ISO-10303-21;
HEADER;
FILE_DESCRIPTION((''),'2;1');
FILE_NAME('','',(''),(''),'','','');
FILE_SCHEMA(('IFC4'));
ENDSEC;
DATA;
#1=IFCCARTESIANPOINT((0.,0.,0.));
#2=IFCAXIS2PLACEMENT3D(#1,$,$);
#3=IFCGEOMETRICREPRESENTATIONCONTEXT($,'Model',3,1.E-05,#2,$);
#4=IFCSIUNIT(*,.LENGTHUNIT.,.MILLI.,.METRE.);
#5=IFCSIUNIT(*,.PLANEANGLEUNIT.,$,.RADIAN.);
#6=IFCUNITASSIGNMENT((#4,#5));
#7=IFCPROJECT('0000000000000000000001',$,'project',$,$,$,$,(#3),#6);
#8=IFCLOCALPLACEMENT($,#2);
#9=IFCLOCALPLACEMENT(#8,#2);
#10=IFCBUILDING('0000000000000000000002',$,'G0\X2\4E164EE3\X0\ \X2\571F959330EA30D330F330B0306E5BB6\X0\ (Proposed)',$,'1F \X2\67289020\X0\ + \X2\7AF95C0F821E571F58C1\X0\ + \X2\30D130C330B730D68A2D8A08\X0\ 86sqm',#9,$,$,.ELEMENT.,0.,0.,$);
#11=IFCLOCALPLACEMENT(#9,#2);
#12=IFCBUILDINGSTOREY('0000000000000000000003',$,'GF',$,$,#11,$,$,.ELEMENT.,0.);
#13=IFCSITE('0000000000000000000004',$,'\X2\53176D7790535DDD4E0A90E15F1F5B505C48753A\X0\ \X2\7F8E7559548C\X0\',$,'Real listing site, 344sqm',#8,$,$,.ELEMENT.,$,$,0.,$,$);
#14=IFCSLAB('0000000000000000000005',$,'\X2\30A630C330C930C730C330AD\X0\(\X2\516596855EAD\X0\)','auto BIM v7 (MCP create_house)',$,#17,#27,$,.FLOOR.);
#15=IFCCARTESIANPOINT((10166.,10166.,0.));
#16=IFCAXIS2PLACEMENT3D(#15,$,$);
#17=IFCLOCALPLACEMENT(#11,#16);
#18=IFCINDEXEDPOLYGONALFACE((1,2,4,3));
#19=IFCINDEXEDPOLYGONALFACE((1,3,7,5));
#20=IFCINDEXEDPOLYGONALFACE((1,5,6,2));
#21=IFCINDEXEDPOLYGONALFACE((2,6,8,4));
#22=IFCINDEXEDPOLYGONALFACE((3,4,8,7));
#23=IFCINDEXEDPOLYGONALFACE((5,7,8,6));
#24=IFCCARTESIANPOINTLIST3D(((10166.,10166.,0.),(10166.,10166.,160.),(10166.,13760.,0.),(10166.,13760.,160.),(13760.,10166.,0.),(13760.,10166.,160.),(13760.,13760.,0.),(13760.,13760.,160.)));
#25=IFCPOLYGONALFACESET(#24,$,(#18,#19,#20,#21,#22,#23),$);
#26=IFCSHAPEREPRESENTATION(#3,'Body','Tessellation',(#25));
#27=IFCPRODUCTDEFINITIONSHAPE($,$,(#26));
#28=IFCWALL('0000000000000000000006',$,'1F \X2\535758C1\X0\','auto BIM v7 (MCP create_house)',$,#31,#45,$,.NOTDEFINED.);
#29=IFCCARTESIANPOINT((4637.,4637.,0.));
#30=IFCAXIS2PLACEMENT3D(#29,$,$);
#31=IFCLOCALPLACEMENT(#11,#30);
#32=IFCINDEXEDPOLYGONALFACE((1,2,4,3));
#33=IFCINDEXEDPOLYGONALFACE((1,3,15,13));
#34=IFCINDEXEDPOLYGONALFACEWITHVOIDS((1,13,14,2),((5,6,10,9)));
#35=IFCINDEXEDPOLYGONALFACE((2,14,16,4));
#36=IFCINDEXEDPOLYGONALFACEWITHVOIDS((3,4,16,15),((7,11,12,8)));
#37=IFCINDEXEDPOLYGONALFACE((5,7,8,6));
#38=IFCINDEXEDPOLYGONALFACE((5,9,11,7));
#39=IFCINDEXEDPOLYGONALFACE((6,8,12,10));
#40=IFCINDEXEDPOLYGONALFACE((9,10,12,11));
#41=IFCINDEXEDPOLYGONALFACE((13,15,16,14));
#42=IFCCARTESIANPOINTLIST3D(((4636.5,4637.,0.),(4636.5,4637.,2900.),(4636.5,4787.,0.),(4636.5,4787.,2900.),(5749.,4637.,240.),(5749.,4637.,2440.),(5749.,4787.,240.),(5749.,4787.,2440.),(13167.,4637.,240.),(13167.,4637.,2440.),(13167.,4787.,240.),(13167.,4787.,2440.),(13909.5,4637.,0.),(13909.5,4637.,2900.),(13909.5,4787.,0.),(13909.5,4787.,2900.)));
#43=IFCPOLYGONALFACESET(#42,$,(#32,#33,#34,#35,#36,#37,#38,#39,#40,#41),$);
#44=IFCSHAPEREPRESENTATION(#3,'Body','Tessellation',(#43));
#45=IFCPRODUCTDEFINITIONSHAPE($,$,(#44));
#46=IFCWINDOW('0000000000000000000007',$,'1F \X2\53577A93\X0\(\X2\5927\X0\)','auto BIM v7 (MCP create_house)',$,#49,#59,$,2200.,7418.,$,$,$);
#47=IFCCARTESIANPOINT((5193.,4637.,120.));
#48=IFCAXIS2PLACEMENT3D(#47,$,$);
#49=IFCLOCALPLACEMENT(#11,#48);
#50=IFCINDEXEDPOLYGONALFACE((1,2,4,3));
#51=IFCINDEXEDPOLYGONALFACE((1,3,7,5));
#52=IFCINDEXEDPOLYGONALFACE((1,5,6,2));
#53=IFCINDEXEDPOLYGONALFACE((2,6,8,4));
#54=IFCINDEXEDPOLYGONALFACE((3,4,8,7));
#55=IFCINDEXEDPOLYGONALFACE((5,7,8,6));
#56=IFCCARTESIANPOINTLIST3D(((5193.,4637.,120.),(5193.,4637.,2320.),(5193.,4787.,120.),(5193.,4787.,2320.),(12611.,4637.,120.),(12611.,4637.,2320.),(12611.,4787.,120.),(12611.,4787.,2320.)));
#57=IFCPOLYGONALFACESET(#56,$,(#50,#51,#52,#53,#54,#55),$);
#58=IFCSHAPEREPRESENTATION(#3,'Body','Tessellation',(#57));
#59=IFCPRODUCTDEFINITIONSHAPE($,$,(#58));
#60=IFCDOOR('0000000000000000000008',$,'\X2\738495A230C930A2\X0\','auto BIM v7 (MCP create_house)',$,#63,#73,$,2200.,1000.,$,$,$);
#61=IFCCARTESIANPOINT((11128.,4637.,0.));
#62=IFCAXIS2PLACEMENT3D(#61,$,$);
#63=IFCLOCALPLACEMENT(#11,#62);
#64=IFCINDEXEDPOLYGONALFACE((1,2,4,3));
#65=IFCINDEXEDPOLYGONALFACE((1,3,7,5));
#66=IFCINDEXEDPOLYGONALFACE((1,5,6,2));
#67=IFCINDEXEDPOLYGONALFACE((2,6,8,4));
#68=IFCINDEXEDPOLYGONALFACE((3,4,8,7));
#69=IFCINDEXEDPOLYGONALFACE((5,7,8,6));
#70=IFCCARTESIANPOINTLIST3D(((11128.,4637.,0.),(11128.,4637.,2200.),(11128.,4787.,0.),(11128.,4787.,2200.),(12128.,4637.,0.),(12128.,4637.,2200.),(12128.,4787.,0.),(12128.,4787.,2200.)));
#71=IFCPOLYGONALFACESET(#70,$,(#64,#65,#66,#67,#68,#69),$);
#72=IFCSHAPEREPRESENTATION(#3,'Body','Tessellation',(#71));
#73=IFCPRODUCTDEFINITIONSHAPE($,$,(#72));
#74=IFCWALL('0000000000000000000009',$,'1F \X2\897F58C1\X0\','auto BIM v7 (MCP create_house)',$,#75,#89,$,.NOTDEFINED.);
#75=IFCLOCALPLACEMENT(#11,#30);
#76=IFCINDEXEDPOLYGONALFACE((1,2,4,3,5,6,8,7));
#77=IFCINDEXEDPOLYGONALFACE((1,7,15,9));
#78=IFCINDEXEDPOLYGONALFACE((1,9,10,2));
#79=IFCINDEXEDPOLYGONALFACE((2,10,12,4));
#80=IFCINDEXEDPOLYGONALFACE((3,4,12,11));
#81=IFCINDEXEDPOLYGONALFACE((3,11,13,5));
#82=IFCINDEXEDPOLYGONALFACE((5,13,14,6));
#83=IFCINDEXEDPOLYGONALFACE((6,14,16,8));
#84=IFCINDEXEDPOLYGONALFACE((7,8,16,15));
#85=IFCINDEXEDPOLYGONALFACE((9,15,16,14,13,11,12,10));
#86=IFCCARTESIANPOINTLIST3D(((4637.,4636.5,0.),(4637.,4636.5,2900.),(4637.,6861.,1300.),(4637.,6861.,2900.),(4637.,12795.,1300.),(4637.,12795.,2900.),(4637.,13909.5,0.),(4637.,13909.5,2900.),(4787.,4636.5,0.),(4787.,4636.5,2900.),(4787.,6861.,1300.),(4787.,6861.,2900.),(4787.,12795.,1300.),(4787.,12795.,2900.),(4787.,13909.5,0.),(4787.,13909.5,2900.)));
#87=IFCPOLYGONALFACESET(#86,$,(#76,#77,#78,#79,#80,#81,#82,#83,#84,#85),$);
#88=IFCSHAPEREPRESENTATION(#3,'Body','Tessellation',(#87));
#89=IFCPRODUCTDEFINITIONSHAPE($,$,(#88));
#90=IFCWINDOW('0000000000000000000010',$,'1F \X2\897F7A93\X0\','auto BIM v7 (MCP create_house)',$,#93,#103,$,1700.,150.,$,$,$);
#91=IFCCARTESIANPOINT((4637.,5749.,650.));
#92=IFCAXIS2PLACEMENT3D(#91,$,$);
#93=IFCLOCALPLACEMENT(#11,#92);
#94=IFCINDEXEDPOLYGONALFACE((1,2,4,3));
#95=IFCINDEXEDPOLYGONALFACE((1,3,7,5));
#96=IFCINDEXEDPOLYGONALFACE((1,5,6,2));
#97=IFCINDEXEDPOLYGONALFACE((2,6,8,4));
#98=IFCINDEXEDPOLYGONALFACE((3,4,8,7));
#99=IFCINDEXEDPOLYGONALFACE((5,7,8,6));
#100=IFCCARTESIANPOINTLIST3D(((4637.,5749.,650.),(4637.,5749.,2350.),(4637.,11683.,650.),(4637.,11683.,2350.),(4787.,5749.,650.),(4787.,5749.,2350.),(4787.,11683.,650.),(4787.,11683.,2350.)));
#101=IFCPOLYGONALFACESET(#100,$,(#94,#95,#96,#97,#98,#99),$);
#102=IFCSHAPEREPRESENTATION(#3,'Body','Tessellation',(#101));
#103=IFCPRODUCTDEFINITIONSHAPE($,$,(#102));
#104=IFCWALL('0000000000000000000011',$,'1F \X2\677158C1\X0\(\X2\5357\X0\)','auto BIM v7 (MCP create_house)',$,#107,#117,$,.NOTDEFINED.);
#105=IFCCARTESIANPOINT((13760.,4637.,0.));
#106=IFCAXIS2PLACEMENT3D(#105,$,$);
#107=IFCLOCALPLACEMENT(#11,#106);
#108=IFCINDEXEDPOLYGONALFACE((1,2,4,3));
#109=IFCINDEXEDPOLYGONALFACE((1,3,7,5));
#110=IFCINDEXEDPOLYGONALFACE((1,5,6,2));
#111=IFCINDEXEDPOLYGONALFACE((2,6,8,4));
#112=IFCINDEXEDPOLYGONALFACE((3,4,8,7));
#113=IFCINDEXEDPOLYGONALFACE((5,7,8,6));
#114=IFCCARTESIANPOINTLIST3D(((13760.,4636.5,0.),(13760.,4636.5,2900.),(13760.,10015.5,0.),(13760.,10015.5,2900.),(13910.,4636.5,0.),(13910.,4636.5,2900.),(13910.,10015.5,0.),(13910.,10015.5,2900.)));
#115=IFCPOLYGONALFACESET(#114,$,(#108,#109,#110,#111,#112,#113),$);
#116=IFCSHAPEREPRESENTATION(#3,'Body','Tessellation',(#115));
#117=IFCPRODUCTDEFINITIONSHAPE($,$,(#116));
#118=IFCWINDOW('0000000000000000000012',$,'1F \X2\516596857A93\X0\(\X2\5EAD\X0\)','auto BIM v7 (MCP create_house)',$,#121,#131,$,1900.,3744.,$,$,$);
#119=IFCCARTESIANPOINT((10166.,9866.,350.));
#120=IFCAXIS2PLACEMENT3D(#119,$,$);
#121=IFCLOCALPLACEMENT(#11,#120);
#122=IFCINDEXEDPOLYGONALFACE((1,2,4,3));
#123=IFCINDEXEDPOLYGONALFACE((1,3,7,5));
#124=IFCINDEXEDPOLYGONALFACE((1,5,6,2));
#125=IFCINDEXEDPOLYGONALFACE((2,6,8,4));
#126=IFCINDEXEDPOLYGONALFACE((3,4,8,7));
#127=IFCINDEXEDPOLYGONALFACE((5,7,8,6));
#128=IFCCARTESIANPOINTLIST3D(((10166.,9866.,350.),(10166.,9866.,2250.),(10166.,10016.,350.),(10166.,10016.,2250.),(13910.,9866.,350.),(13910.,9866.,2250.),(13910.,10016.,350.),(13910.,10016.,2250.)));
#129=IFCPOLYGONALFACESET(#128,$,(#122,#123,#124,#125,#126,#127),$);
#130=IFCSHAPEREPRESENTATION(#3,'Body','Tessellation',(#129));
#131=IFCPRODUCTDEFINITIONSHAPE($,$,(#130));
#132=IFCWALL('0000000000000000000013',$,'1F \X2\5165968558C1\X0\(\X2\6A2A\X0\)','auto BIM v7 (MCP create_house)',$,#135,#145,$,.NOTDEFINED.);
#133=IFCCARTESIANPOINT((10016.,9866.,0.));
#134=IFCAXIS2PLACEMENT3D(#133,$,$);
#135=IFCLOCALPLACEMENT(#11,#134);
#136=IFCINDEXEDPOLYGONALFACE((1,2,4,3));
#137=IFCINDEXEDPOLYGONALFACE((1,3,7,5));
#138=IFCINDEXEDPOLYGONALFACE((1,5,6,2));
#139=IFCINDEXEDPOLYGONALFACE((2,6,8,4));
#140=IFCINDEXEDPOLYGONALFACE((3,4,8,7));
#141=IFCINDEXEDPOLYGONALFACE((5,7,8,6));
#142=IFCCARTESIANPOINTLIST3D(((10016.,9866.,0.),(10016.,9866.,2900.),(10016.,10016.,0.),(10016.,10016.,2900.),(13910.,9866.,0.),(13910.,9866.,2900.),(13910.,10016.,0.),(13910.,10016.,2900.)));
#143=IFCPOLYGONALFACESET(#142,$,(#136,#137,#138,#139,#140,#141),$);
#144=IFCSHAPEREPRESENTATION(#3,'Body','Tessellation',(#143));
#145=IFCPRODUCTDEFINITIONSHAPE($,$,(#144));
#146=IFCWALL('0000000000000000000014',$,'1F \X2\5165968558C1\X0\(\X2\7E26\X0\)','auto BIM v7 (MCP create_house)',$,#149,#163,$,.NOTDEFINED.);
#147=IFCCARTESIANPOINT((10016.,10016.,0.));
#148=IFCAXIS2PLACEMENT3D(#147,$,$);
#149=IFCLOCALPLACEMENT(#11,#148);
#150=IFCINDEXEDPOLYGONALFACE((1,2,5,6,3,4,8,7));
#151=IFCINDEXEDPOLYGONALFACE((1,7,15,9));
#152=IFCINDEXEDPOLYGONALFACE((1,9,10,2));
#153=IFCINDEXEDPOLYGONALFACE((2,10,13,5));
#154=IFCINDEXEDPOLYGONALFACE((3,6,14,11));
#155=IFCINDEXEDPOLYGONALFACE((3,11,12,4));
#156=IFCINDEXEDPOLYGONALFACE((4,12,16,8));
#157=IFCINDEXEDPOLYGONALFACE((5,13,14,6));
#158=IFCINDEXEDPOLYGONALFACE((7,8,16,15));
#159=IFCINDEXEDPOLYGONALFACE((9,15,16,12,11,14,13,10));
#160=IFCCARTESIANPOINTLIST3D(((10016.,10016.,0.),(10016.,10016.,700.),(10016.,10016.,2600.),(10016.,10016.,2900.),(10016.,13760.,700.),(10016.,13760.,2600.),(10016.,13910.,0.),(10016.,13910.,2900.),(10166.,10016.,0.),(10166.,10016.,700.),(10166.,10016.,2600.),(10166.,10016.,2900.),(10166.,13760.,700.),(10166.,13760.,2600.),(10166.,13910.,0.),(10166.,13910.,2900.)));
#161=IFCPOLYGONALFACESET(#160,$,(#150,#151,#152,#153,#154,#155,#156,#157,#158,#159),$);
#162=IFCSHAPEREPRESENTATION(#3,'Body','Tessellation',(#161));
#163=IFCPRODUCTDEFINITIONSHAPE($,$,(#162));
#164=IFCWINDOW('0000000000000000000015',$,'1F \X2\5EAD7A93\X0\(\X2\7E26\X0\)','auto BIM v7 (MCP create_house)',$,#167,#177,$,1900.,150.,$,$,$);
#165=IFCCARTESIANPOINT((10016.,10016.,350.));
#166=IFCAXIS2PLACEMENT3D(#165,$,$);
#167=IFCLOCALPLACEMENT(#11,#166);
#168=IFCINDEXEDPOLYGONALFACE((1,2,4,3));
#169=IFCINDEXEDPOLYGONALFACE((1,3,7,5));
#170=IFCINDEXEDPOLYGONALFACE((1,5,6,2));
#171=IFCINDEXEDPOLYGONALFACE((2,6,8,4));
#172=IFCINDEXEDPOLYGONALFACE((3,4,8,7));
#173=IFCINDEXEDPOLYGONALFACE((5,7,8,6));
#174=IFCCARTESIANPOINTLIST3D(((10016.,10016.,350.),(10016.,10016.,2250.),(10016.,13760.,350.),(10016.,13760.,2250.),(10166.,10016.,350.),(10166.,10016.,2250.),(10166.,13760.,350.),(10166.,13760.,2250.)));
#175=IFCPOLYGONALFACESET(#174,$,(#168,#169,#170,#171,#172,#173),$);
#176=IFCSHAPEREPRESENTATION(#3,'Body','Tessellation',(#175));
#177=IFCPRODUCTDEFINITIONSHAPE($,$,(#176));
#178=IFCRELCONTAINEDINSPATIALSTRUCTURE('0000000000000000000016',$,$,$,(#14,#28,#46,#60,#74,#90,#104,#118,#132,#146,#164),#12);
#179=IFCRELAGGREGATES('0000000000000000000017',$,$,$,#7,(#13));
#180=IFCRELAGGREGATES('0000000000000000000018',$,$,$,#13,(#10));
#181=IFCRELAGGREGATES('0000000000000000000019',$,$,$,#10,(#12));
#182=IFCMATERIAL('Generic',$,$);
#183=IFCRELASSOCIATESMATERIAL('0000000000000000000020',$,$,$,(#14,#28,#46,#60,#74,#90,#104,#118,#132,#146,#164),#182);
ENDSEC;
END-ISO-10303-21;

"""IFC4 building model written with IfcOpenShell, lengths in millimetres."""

from ifc_helpers import new_model, si_unit, frame, frame_2d, origin, place, context, project, spatial, rectangle, extrude, material, element, fill, save


model = new_model("IFC4")

# Units and contexts
model_context = context("Model", 3, precision=1e-05, world=origin())
ifc_project = project(units=[si_unit("LENGTHUNIT", "METRE", prefix="MILLI"), si_unit("PLANEANGLEUNIT", "RADIAN")], contexts=[model_context])

# Site, building, storey
site_placement = place(None, origin())
site = spatial("IfcSite", under=ifc_project, at=site_placement, Name="北海道川上郡弟子屈町 美留和", ObjectType="Real listing site, 344sqm", CompositionType="ELEMENT", RefElevation=0.0)
building_placement = place(site_placement, origin())
building = spatial("IfcBuilding", under=site, at=building_placement, Name="G0世代 土間リビングの家 (Proposed)", ObjectType="1F 木造 + 竹小舞土壁 + パッシブ設計 86sqm", CompositionType="ELEMENT", ElevationOfRefHeight=0.0, ElevationOfTerrain=0.0)
storey_placement = place(building_placement, origin())
storey = spatial("IfcBuildingStorey", under=building, at=storey_placement, Name="GF", CompositionType="ELEMENT", Elevation=0.0)

# Slab
ifc_material = material(Name="Generic")
slab_1_placement = place(storey_placement, frame((10166.0, 10166.0, 0.0)))
element("IfcSlab", 1, at=slab_1_placement, inside=storey, material=ifc_material, Name="ウッドデッキ(入隅庭)", Description="auto BIM v7 (MCP create_house)", PredefinedType="FLOOR", context=model_context, shape_type="SweptSolid", body=[
    extrude(rectangle(XDim=3594.0, YDim=3594.0, at=frame_2d((1797.0, 1797.0))), frame((10166.0, 10166.0, 0.0)), (0.0, 0.0, 1.0), 160.0),
])

# Wall, openings, window, door
wall_1_placement = place(storey_placement, frame((4637.0, 4637.0, 0.0)))
wall_1 = element("IfcWall", 2, at=wall_1_placement, inside=storey, material=ifc_material, Name="1F 南壁", Description="auto BIM v7 (MCP create_house)", PredefinedType="NOTDEFINED", context=model_context, shape_type="SweptSolid", body=[
    extrude(rectangle(XDim=9273.0, YDim=150.0, at=frame_2d((4636.0, 75.0))), frame((4637.0, 4637.0, 0.0)), (0.0, 0.0, 1.0), 2900.0),
])
opening_1_placement = place(storey_placement, frame((5193.0, 4637.0, 120.0)))
opening_1 = element("IfcOpeningElement", 3, at=opening_1_placement, cuts=wall_1, PredefinedType="NOTDEFINED", context=model_context, shape_type="SweptSolid", body=[
    extrude(rectangle(XDim=7418.0, YDim=150.0, at=frame_2d((3709.0, 75.0))), frame((5193.0, 4637.0, 120.0)), (0.0, 0.0, 1.0), 2200.0),
])
opening_2_placement = place(storey_placement, frame((11128.0, 4637.0, 0.0)))
opening_2 = element("IfcOpeningElement", 4, at=opening_2_placement, cuts=wall_1, PredefinedType="NOTDEFINED", context=model_context, shape_type="SweptSolid", body=[
    extrude(rectangle(XDim=1000.0, YDim=150.0, at=frame_2d((500.0, 75.0))), frame((11128.0, 4637.0, 0.0)), (0.0, 0.0, 1.0), 2200.0),
])
window_1_placement = place(storey_placement, frame((5193.0, 4637.0, 120.0)))
window_1 = element("IfcWindow", 5, at=window_1_placement, inside=storey, material=ifc_material, Name="1F 南窓(大)", Description="auto BIM v7 (MCP create_house)", OverallHeight=2200.0, OverallWidth=7418.0, context=model_context, shape_type="SweptSolid", body=[
    extrude(rectangle(XDim=7418.0, YDim=150.0, at=frame_2d((3709.0, 75.0))), frame((5193.0, 4637.0, 120.0)), (0.0, 0.0, 1.0), 2200.0),
])
fill(opening_1, window_1)
door_placement = place(storey_placement, frame((11128.0, 4637.0, 0.0)))
door = element("IfcDoor", 6, at=door_placement, inside=storey, material=ifc_material, Name="玄関ドア", Description="auto BIM v7 (MCP create_house)", OverallHeight=2200.0, OverallWidth=1000.0, context=model_context, shape_type="SweptSolid", body=[
    extrude(rectangle(XDim=1000.0, YDim=150.0, at=frame_2d((500.0, 75.0))), frame((11128.0, 4637.0, 0.0)), (0.0, 0.0, 1.0), 2200.0),
])
fill(opening_2, door)

# Wall, opening, window
wall_2_placement = place(storey_placement, frame((4637.0, 4637.0, 0.0)))
wall_2 = element("IfcWall", 7, at=wall_2_placement, inside=storey, material=ifc_material, Name="1F 西壁", Description="auto BIM v7 (MCP create_house)", PredefinedType="NOTDEFINED", context=model_context, shape_type="SweptSolid", body=[
    extrude(rectangle(XDim=150.0, YDim=9273.0, at=frame_2d((75.0, 4636.0))), frame((4637.0, 4637.0, 0.0)), (0.0, 0.0, 1.0), 2900.0),
])
opening_3_placement = place(storey_placement, frame((4637.0, 5749.0, 650.0)))
opening_3 = element("IfcOpeningElement", 8, at=opening_3_placement, cuts=wall_2, PredefinedType="NOTDEFINED", context=model_context, shape_type="SweptSolid", body=[
    extrude(rectangle(XDim=150.0, YDim=5934.0, at=frame_2d((75.0, 2967.0))), frame((4637.0, 5749.0, 650.0)), (0.0, 0.0, 1.0), 1700.0),
])
window_2_placement = place(storey_placement, frame((4637.0, 5749.0, 650.0)))
window_2 = element("IfcWindow", 9, at=window_2_placement, inside=storey, material=ifc_material, Name="1F 西窓", Description="auto BIM v7 (MCP create_house)", OverallHeight=1700.0, OverallWidth=150.0, context=model_context, shape_type="SweptSolid", body=[
    extrude(rectangle(XDim=150.0, YDim=5934.0, at=frame_2d((75.0, 2967.0))), frame((4637.0, 5749.0, 650.0)), (0.0, 0.0, 1.0), 1700.0),
])
fill(opening_3, window_2)

# Wall, opening, window
wall_3_placement = place(storey_placement, frame((13760.0, 4637.0, 0.0)))
wall_3 = element("IfcWall", 10, at=wall_3_placement, inside=storey, material=ifc_material, Name="1F 東壁(南)", Description="auto BIM v7 (MCP create_house)", PredefinedType="NOTDEFINED", context=model_context, shape_type="SweptSolid", body=[
    extrude(rectangle(XDim=150.0, YDim=5379.0, at=frame_2d((75.0, 2689.0))), frame((13760.0, 4637.0, 0.0)), (0.0, 0.0, 1.0), 2900.0),
])
opening_4_placement = place(storey_placement, frame((10166.0, 9866.0, 350.0)))
opening_4 = element("IfcOpeningElement", 11, at=opening_4_placement, cuts=wall_3, PredefinedType="NOTDEFINED", context=model_context, shape_type="SweptSolid", body=[
    extrude(rectangle(XDim=3744.0, YDim=150.0, at=frame_2d((1872.0, 75.0))), frame((10166.0, 9866.0, 350.0)), (0.0, 0.0, 1.0), 1900.0),
])
window_3_placement = place(storey_placement, frame((10166.0, 9866.0, 350.0)))
window_3 = element("IfcWindow", 12, at=window_3_placement, inside=storey, material=ifc_material, Name="1F 入隅窓(庭)", Description="auto BIM v7 (MCP create_house)", OverallHeight=1900.0, OverallWidth=3744.0, context=model_context, shape_type="SweptSolid", body=[
    extrude(rectangle(XDim=3744.0, YDim=150.0, at=frame_2d((1872.0, 75.0))), frame((10166.0, 9866.0, 350.0)), (0.0, 0.0, 1.0), 1900.0),
])
fill(opening_4, window_3)

# Wall
wall_4_placement = place(storey_placement, frame((10016.0, 9866.0, 0.0)))
element("IfcWall", 13, at=wall_4_placement, inside=storey, material=ifc_material, Name="1F 入隅壁(横)", Description="auto BIM v7 (MCP create_house)", PredefinedType="NOTDEFINED", context=model_context, shape_type="SweptSolid", body=[
    extrude(rectangle(XDim=3894.0, YDim=150.0, at=frame_2d((1947.0, 75.0))), frame((10016.0, 9866.0, 0.0)), (0.0, 0.0, 1.0), 2900.0),
])

# Wall, opening, window
wall_5_placement = place(storey_placement, frame((10016.0, 10016.0, 0.0)))
wall_5 = element("IfcWall", 14, at=wall_5_placement, inside=storey, material=ifc_material, Name="1F 入隅壁(縦)", Description="auto BIM v7 (MCP create_house)", PredefinedType="NOTDEFINED", context=model_context, shape_type="SweptSolid", body=[
    extrude(rectangle(XDim=150.0, YDim=3894.0, at=frame_2d((75.0, 1947.0))), frame((10016.0, 10016.0, 0.0)), (0.0, 0.0, 1.0), 2900.0),
])
opening_5_placement = place(storey_placement, frame((10016.0, 10016.0, 350.0)))
opening_5 = element("IfcOpeningElement", 15, at=opening_5_placement, cuts=wall_5, PredefinedType="NOTDEFINED", context=model_context, shape_type="SweptSolid", body=[
    extrude(rectangle(XDim=150.0, YDim=3744.0, at=frame_2d((75.0, 1872.0))), frame((10016.0, 10016.0, 350.0)), (0.0, 0.0, 1.0), 1900.0),
])
window_4_placement = place(storey_placement, frame((10016.0, 10016.0, 350.0)))
window_4 = element("IfcWindow", 16, at=window_4_placement, inside=storey, material=ifc_material, Name="1F 庭窓(縦)", Description="auto BIM v7 (MCP create_house)", OverallHeight=1900.0, OverallWidth=150.0, context=model_context, shape_type="SweptSolid", body=[
    extrude(rectangle(XDim=150.0, YDim=3744.0, at=frame_2d((75.0, 1872.0))), frame((10016.0, 10016.0, 350.0)), (0.0, 0.0, 1.0), 1900.0),
])
fill(opening_5, window_4)

save(model, "model.ifc")
